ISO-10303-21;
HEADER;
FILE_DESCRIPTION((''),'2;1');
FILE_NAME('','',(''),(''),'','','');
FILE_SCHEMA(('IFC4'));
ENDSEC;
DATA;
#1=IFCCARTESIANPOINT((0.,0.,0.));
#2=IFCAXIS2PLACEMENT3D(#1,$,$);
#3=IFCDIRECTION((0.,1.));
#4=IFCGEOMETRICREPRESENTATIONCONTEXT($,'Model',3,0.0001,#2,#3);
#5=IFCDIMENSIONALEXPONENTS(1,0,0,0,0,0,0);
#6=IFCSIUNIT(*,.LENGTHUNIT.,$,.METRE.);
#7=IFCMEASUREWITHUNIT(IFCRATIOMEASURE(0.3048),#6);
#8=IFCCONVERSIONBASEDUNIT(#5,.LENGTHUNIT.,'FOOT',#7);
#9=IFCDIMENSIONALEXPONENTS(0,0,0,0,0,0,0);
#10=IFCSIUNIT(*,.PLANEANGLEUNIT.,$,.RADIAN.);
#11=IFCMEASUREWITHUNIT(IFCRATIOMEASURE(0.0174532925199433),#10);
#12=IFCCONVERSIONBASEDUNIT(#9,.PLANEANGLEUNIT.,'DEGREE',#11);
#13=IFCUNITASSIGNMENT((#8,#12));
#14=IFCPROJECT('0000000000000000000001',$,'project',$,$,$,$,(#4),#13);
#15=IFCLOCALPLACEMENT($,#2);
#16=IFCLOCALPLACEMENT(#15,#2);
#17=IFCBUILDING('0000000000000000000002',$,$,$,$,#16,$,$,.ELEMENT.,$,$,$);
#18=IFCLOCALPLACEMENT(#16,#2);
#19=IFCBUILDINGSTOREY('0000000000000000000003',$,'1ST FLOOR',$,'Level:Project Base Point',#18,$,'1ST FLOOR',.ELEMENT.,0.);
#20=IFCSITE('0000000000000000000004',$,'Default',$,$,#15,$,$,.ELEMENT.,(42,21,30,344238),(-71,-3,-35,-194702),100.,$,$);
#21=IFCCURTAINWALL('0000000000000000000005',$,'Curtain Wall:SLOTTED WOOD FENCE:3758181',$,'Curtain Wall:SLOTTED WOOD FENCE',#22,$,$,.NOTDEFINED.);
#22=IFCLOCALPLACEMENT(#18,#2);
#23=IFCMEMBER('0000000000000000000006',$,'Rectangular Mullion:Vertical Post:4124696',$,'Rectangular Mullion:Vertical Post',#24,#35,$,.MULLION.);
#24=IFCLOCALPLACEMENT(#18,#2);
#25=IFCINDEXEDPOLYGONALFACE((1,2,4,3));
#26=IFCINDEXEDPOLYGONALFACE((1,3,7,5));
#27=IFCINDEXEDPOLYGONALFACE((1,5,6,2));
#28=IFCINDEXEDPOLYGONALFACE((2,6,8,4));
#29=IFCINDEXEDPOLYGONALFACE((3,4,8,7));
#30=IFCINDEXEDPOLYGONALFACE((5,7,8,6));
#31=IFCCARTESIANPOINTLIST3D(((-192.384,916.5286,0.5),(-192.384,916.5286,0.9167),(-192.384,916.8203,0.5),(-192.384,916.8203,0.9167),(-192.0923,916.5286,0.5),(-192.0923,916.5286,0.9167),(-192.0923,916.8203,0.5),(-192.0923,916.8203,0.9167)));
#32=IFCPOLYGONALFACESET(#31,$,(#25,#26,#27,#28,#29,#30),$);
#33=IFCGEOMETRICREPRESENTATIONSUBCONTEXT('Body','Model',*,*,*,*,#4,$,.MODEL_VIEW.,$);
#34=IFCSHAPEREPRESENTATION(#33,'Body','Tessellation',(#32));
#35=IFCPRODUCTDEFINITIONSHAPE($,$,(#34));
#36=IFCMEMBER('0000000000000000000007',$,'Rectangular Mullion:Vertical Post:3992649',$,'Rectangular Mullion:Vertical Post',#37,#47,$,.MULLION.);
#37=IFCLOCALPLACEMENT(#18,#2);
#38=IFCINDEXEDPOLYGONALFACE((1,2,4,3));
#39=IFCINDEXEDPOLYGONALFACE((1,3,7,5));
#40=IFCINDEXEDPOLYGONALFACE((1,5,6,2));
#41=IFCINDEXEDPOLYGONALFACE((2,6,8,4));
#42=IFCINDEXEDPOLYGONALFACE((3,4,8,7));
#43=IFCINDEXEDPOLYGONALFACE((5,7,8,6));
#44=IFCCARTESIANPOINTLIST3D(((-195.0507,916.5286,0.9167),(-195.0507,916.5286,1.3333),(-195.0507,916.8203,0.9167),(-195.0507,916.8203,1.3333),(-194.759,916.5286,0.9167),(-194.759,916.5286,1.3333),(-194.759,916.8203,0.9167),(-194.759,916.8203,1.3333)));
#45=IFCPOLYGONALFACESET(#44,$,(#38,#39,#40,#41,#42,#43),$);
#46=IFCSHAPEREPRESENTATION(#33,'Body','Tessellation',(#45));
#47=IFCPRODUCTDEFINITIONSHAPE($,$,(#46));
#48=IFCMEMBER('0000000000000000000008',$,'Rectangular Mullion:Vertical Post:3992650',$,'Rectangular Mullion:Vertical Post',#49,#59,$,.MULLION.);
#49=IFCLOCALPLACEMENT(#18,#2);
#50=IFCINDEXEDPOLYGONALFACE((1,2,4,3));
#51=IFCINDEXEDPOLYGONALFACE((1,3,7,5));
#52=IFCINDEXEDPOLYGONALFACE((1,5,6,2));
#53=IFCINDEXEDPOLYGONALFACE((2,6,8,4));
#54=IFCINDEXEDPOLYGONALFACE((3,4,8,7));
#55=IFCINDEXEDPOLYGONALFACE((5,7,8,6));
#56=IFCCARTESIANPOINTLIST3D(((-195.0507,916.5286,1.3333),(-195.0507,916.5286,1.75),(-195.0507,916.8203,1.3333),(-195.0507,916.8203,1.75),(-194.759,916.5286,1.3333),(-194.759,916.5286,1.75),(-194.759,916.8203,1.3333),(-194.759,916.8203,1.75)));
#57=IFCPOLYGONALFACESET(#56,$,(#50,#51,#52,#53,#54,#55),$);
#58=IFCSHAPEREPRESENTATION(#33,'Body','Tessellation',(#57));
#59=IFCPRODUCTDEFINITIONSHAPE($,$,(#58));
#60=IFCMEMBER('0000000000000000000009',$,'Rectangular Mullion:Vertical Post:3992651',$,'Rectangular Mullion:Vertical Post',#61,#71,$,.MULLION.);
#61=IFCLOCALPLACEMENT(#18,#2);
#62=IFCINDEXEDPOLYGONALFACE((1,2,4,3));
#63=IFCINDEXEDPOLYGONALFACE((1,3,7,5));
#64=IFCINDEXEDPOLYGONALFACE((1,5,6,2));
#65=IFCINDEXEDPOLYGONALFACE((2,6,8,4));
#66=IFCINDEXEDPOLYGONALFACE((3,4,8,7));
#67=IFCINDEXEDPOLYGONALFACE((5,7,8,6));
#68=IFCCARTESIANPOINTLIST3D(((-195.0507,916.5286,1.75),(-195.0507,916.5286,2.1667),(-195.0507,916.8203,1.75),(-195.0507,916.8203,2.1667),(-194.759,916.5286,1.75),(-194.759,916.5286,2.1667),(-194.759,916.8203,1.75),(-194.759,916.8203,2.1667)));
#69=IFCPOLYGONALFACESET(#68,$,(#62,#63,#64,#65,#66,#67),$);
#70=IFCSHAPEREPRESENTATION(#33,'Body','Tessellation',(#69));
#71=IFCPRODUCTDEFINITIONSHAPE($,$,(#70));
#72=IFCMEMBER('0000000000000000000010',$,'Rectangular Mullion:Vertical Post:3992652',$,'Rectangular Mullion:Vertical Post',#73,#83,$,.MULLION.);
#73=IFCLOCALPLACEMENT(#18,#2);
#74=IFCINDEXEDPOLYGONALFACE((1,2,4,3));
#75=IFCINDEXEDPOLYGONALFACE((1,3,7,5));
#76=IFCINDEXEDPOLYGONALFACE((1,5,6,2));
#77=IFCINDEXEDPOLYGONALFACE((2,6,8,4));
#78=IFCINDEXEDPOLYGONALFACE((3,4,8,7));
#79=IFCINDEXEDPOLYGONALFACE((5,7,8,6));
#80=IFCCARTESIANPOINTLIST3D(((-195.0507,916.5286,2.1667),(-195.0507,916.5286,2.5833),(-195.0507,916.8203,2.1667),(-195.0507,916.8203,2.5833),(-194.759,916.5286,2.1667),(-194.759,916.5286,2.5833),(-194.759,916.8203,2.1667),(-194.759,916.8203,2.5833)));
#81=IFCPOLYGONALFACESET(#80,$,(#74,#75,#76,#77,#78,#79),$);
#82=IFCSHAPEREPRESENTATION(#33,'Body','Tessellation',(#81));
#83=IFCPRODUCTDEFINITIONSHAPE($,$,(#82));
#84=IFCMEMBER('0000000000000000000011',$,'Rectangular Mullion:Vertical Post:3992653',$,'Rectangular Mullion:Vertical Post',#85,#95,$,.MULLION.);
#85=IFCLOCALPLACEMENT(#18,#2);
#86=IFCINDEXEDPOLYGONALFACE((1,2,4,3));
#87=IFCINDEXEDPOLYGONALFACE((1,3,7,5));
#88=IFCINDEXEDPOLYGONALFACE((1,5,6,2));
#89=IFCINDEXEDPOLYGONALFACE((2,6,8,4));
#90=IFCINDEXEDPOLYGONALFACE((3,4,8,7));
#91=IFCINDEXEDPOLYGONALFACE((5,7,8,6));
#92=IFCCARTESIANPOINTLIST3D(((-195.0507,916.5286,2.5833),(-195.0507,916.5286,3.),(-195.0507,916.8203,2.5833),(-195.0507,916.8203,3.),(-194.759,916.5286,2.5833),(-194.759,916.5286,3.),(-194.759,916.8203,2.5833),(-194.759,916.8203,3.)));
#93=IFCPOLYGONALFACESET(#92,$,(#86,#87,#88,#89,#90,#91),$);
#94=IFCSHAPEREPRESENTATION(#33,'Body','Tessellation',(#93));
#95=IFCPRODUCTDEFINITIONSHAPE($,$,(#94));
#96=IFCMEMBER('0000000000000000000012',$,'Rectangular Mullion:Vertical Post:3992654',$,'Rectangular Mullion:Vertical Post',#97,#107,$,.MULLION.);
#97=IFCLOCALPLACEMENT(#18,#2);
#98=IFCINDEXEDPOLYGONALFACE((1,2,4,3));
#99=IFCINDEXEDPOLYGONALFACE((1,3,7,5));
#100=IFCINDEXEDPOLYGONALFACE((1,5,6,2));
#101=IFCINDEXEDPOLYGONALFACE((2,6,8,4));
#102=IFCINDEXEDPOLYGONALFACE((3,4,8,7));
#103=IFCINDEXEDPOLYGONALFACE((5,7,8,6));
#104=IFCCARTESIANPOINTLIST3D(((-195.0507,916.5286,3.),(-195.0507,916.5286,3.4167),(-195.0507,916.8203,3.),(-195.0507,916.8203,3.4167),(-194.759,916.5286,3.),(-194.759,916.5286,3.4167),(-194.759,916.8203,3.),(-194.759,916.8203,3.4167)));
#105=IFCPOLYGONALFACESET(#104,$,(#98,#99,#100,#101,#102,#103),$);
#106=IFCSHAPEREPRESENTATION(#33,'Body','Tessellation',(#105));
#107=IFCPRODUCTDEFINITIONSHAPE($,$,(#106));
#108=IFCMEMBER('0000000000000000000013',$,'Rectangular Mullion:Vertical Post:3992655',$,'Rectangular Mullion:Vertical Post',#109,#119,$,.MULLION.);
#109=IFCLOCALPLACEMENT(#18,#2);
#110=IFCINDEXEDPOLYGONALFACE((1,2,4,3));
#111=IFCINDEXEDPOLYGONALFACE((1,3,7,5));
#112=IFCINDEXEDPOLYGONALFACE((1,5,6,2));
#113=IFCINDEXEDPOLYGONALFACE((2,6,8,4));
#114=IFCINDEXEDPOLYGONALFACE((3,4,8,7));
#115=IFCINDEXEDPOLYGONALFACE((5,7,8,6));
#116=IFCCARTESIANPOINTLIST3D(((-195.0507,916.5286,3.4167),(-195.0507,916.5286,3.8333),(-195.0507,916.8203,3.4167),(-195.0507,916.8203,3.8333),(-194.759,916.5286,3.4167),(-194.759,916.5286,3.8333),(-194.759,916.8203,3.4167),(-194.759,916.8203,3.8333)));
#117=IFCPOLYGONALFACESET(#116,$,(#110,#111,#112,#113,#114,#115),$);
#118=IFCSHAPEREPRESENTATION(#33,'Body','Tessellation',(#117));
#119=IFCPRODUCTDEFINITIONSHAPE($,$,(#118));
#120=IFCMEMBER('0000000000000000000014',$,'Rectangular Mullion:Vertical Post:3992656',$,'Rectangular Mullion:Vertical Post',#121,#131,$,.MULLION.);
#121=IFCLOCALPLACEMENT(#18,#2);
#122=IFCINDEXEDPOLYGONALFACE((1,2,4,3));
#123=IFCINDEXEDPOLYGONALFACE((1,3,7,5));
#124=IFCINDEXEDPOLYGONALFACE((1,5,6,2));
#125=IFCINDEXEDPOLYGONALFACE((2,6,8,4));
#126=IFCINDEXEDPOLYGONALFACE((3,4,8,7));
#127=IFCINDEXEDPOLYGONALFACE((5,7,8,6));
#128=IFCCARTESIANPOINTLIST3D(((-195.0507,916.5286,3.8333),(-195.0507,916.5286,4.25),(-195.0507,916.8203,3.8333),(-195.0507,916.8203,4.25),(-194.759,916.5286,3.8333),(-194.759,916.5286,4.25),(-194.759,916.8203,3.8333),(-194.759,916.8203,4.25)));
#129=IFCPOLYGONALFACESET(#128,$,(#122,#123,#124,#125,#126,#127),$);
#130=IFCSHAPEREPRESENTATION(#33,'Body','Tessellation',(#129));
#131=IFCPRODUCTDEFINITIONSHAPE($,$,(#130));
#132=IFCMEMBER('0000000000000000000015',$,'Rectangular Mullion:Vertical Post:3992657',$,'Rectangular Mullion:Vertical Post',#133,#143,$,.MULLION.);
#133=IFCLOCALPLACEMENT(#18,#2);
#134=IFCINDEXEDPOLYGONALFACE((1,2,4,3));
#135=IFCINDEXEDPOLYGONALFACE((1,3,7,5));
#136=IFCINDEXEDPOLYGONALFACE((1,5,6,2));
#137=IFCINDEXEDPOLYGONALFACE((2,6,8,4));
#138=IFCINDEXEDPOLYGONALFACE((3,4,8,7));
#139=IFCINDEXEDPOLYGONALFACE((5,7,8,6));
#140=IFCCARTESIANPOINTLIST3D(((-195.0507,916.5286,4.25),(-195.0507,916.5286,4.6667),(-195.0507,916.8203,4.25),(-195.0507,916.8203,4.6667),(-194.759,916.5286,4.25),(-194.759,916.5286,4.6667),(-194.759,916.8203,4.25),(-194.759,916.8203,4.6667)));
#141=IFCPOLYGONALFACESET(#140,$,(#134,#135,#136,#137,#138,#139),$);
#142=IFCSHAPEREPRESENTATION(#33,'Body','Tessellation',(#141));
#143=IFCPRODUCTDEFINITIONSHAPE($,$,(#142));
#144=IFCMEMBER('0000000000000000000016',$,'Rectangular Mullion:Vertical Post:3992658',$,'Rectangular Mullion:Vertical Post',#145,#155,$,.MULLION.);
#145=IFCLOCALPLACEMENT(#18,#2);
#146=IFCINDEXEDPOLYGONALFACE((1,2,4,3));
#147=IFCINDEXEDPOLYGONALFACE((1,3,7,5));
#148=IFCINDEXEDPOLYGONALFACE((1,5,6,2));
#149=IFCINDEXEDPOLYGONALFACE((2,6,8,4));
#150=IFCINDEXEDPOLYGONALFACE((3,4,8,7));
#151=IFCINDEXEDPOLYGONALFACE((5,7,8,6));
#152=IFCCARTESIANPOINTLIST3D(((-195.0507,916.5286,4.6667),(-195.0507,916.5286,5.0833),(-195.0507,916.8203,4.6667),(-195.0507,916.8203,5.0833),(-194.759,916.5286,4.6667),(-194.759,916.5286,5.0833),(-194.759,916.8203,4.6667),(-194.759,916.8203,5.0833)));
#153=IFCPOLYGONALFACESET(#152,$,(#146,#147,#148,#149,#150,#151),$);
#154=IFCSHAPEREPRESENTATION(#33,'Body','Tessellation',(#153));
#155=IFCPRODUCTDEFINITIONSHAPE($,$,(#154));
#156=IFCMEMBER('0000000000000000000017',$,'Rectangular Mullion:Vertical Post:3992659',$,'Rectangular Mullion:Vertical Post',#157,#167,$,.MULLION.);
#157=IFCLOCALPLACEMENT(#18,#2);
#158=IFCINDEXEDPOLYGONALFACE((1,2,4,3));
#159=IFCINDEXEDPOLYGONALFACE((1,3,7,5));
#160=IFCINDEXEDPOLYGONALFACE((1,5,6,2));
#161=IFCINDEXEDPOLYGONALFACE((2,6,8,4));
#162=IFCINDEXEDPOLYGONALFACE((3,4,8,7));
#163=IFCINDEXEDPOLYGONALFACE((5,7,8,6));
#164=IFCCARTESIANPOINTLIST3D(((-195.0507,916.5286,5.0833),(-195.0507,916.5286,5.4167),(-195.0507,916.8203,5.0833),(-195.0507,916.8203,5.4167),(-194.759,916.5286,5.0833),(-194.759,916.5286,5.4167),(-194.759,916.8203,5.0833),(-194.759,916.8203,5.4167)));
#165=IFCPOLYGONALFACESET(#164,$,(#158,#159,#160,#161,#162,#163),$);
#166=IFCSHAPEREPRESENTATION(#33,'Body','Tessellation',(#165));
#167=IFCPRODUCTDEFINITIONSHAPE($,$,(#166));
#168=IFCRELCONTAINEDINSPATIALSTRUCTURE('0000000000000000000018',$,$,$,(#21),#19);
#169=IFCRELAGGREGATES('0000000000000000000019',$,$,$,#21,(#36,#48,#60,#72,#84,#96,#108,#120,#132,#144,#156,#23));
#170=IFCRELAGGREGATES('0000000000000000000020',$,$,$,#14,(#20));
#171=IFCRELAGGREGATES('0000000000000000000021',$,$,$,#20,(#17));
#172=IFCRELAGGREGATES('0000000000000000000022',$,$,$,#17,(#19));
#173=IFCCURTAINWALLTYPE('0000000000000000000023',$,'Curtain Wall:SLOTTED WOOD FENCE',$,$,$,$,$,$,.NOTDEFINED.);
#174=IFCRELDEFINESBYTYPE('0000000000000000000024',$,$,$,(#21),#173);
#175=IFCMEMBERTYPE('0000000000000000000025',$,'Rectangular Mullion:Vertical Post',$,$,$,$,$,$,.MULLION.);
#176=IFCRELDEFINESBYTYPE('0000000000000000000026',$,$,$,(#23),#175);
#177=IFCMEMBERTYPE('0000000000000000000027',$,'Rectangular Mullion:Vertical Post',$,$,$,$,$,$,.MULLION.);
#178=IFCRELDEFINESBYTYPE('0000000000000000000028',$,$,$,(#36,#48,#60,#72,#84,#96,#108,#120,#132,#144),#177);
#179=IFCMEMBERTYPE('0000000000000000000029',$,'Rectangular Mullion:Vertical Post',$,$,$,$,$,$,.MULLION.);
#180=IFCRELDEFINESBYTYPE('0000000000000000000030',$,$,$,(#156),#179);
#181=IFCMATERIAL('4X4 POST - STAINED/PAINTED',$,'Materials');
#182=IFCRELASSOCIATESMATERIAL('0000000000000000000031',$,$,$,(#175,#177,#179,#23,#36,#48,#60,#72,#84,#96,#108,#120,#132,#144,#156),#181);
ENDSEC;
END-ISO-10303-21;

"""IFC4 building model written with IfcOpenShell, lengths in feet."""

from ifc_helpers import new_model, entity, si_unit, converted_unit, direction, frame, origin, origin_2d_with_axis, place, context, subcontext, project, spatial, rectangle, extrude, source, transform, mapped, material, material_profile, profile_set, profile_usage, type_object, type_shapes, element, aggregate, save


model = new_model("IFC4")

# Units and contexts
model_context = context("Model", 3, precision=0.0001, world=origin(), true_north=direction((0.0, 1.0)))
body_context = subcontext(model_context, "Body", "Model", "MODEL_VIEW")
ifc_project = project(units=[converted_unit("LENGTHUNIT", "FOOT", entity("IfcRatioMeasure", 0.3048), si_unit("LENGTHUNIT", "METRE"), dimensions=[1, 0, 0, 0, 0, 0, 0]), converted_unit("PLANEANGLEUNIT", "DEGREE", entity("IfcRatioMeasure", 0.0174532925199433), si_unit("PLANEANGLEUNIT", "RADIAN"), dimensions=[0, 0, 0, 0, 0, 0, 0])], contexts=[model_context])

# Site, building, storey
site_placement = place(None, origin())
site = spatial("IfcSite", under=ifc_project, at=site_placement, Name="Default", CompositionType="ELEMENT", RefLatitude=(42, 21, 30, 344238), RefLongitude=(-71, -3, -35, -194702), RefElevation=100.0)
building_placement = place(site_placement, origin())
building = spatial("IfcBuilding", under=site, at=building_placement, CompositionType="ELEMENT")
storey_placement = place(building_placement, origin())
storey = spatial("IfcBuildingStorey", under=building, at=storey_placement, Name="1ST FLOOR", ObjectType="Level:Project Base Point", LongName="1ST FLOOR", CompositionType="ELEMENT", Elevation=0.0)

# Curtain wall, members
curtain_wall_type = type_object("IfcCurtainWallType", Name="Curtain Wall:SLOTTED WOOD FENCE", PredefinedType="NOTDEFINED")
curtain_wall_placement = place(storey_placement, origin())
curtain_wall = element("IfcCurtainWall", 1, at=curtain_wall_placement, inside=storey, type_object=curtain_wall_type, Name="Curtain Wall:SLOTTED WOOD FENCE:3758181", ObjectType="Curtain Wall:SLOTTED WOOD FENCE", PredefinedType="NOTDEFINED")
ifc_material_1 = material(Name="4X4 POST - STAINED/PAINTED", Category="Materials")
ifc_material_profile = material_profile(ifc_material_1, rectangle(XDim=0.2917, YDim=0.2917, at=origin_2d_with_axis()), Name="Vertical Post")
ifc_profile_set = profile_set([ifc_material_profile], Name="Vertical Post")
ifc_profile_usage_1 = profile_usage(ifc_profile_set)
member_type_1 = type_object("IfcMemberType", Name="Rectangular Mullion:Vertical Post", PredefinedType="MULLION", material=ifc_profile_set)
shared_shape_1 = source(origin(), body_context, "Body", "SweptSolid", [
    extrude(rectangle(XDim=0.2917, YDim=0.2917, at=origin_2d_with_axis()), frame((0.0, -0.2083, -0.4167), z_axis=(0.0, 0.0, 1.0), x_axis=(0.0, -1.0, 0.0)), (0.0, 0.0, 1.0), 0.4167),
])
type_shapes(member_type_1, [shared_shape_1])
member_1_placement = place(storey_placement, frame((-192.2382, 916.4661, 0.5), z_axis=(0.0, 0.0, -1.0), x_axis=(1.0, 0.0, 0.0)))
member_1 = element("IfcMember", 2, at=member_1_placement, type_object=member_type_1, material=ifc_profile_usage_1, Name="Rectangular Mullion:Vertical Post:4124696", ObjectType="Rectangular Mullion:Vertical Post", PredefinedType="MULLION", context=body_context, shape_type="MappedRepresentation", body=[
    mapped(shared_shape_1, transform((0.0, 0.0, 0.0), scale=1.0)),
])
ifc_profile_usage_2 = profile_usage(ifc_profile_set)
member_type_2 = type_object("IfcMemberType", Name="Rectangular Mullion:Vertical Post", PredefinedType="MULLION", material=ifc_profile_set)
shared_shape_2 = source(origin(), body_context, "Body", "SweptSolid", [
    extrude(rectangle(XDim=0.2917, YDim=0.2917, at=origin_2d_with_axis()), frame((0.0, -0.2083, -0.4167), z_axis=(0.0, 0.0, 1.0), x_axis=(0.0, -1.0, 0.0)), (0.0, 0.0, 1.0), 0.4167),
])
type_shapes(member_type_2, [shared_shape_2])
member_2_placement = place(storey_placement, frame((-194.9048, 916.4661, 0.9167), z_axis=(0.0, 0.0, -1.0), x_axis=(1.0, 0.0, 0.0)))
member_2 = element("IfcMember", 3, at=member_2_placement, type_object=member_type_2, material=ifc_profile_usage_2, Name="Rectangular Mullion:Vertical Post:3992649", ObjectType="Rectangular Mullion:Vertical Post", PredefinedType="MULLION", context=body_context, shape_type="MappedRepresentation", body=[
    mapped(shared_shape_2, transform((0.0, 0.0, 0.0), scale=1.0)),
])
ifc_profile_usage_3 = profile_usage(ifc_profile_set)
member_3_placement = place(storey_placement, frame((-194.9048, 916.4661, 1.3333), z_axis=(0.0, 0.0, -1.0), x_axis=(1.0, 0.0, 0.0)))
member_3 = element("IfcMember", 4, at=member_3_placement, type_object=member_type_2, material=ifc_profile_usage_3, Name="Rectangular Mullion:Vertical Post:3992650", ObjectType="Rectangular Mullion:Vertical Post", PredefinedType="MULLION", context=body_context, shape_type="MappedRepresentation", body=[
    mapped(shared_shape_2, transform((0.0, 0.0, 0.0), scale=1.0)),
])
ifc_profile_usage_4 = profile_usage(ifc_profile_set)
member_4_placement = place(storey_placement, frame((-194.9048, 916.4661, 1.75), z_axis=(0.0, 0.0, -1.0), x_axis=(1.0, 0.0, 0.0)))
member_4 = element("IfcMember", 5, at=member_4_placement, type_object=member_type_2, material=ifc_profile_usage_4, Name="Rectangular Mullion:Vertical Post:3992651", ObjectType="Rectangular Mullion:Vertical Post", PredefinedType="MULLION", context=body_context, shape_type="MappedRepresentation", body=[
    mapped(shared_shape_2, transform((0.0, 0.0, 0.0), scale=1.0)),
])
ifc_profile_usage_5 = profile_usage(ifc_profile_set)
member_5_placement = place(storey_placement, frame((-194.9048, 916.4661, 2.1667), z_axis=(0.0, 0.0, -1.0), x_axis=(1.0, 0.0, 0.0)))
member_5 = element("IfcMember", 6, at=member_5_placement, type_object=member_type_2, material=ifc_profile_usage_5, Name="Rectangular Mullion:Vertical Post:3992652", ObjectType="Rectangular Mullion:Vertical Post", PredefinedType="MULLION", context=body_context, shape_type="MappedRepresentation", body=[
    mapped(shared_shape_2, transform((0.0, 0.0, 0.0), scale=1.0)),
])
ifc_profile_usage_6 = profile_usage(ifc_profile_set)
member_6_placement = place(storey_placement, frame((-194.9048, 916.4661, 2.5833), z_axis=(0.0, 0.0, -1.0), x_axis=(1.0, 0.0, 0.0)))
member_6 = element("IfcMember", 7, at=member_6_placement, type_object=member_type_2, material=ifc_profile_usage_6, Name="Rectangular Mullion:Vertical Post:3992653", ObjectType="Rectangular Mullion:Vertical Post", PredefinedType="MULLION", context=body_context, shape_type="MappedRepresentation", body=[
    mapped(shared_shape_2, transform((0.0, 0.0, 0.0), scale=1.0)),
])
ifc_profile_usage_7 = profile_usage(ifc_profile_set)
member_7_placement = place(storey_placement, frame((-194.9048, 916.4661, 3.0), z_axis=(0.0, 0.0, -1.0), x_axis=(1.0, 0.0, 0.0)))
member_7 = element("IfcMember", 8, at=member_7_placement, type_object=member_type_2, material=ifc_profile_usage_7, Name="Rectangular Mullion:Vertical Post:3992654", ObjectType="Rectangular Mullion:Vertical Post", PredefinedType="MULLION", context=body_context, shape_type="MappedRepresentation", body=[
    mapped(shared_shape_2, transform((0.0, 0.0, 0.0), scale=1.0)),
])
ifc_profile_usage_8 = profile_usage(ifc_profile_set)
member_8_placement = place(storey_placement, frame((-194.9048, 916.4661, 3.4167), z_axis=(0.0, 0.0, -1.0), x_axis=(1.0, 0.0, 0.0)))
member_8 = element("IfcMember", 9, at=member_8_placement, type_object=member_type_2, material=ifc_profile_usage_8, Name="Rectangular Mullion:Vertical Post:3992655", ObjectType="Rectangular Mullion:Vertical Post", PredefinedType="MULLION", context=body_context, shape_type="MappedRepresentation", body=[
    mapped(shared_shape_2, transform((0.0, 0.0, 0.0), scale=1.0)),
])
ifc_profile_usage_9 = profile_usage(ifc_profile_set)
member_9_placement = place(storey_placement, frame((-194.9048, 916.4661, 3.8333), z_axis=(0.0, 0.0, -1.0), x_axis=(1.0, 0.0, 0.0)))
member_9 = element("IfcMember", 10, at=member_9_placement, type_object=member_type_2, material=ifc_profile_usage_9, Name="Rectangular Mullion:Vertical Post:3992656", ObjectType="Rectangular Mullion:Vertical Post", PredefinedType="MULLION", context=body_context, shape_type="MappedRepresentation", body=[
    mapped(shared_shape_2, transform((0.0, 0.0, 0.0), scale=1.0)),
])
ifc_profile_usage_10 = profile_usage(ifc_profile_set)
member_10_placement = place(storey_placement, frame((-194.9048, 916.4661, 4.25), z_axis=(0.0, 0.0, -1.0), x_axis=(1.0, 0.0, 0.0)))
member_10 = element("IfcMember", 11, at=member_10_placement, type_object=member_type_2, material=ifc_profile_usage_10, Name="Rectangular Mullion:Vertical Post:3992657", ObjectType="Rectangular Mullion:Vertical Post", PredefinedType="MULLION", context=body_context, shape_type="MappedRepresentation", body=[
    mapped(shared_shape_2, transform((0.0, 0.0, 0.0), scale=1.0)),
])
ifc_profile_usage_11 = profile_usage(ifc_profile_set)
member_11_placement = place(storey_placement, frame((-194.9048, 916.4661, 4.6667), z_axis=(0.0, 0.0, -1.0), x_axis=(1.0, 0.0, 0.0)))
member_11 = element("IfcMember", 12, at=member_11_placement, type_object=member_type_2, material=ifc_profile_usage_11, Name="Rectangular Mullion:Vertical Post:3992658", ObjectType="Rectangular Mullion:Vertical Post", PredefinedType="MULLION", context=body_context, shape_type="MappedRepresentation", body=[
    mapped(shared_shape_2, transform((0.0, 0.0, 0.0), scale=1.0)),
])
ifc_profile_usage_12 = profile_usage(ifc_profile_set)
member_type_3 = type_object("IfcMemberType", Name="Rectangular Mullion:Vertical Post", PredefinedType="MULLION", material=ifc_profile_set)
shared_shape_3 = source(origin(), body_context, "Body", "SweptSolid", [
    extrude(rectangle(XDim=0.2917, YDim=0.2917, at=origin_2d_with_axis()), frame((0.0, -0.2083, -0.3333), z_axis=(0.0, 0.0, 1.0), x_axis=(0.0, -1.0, 0.0)), (0.0, 0.0, 1.0), 0.3333),
])
type_shapes(member_type_3, [shared_shape_3])
member_12_placement = place(storey_placement, frame((-194.9048, 916.4661, 5.0833), z_axis=(0.0, 0.0, -1.0), x_axis=(1.0, 0.0, 0.0)))
member_12 = element("IfcMember", 13, at=member_12_placement, type_object=member_type_3, material=ifc_profile_usage_12, Name="Rectangular Mullion:Vertical Post:3992659", ObjectType="Rectangular Mullion:Vertical Post", PredefinedType="MULLION", context=body_context, shape_type="MappedRepresentation", body=[
    mapped(shared_shape_3, transform((0.0, 0.0, 0.0), scale=1.0)),
])
aggregate(curtain_wall, [member_2, member_3, member_4, member_5, member_6, member_7, member_8, member_9, member_10, member_11, member_12, member_1])

save(model, "model.ifc")
